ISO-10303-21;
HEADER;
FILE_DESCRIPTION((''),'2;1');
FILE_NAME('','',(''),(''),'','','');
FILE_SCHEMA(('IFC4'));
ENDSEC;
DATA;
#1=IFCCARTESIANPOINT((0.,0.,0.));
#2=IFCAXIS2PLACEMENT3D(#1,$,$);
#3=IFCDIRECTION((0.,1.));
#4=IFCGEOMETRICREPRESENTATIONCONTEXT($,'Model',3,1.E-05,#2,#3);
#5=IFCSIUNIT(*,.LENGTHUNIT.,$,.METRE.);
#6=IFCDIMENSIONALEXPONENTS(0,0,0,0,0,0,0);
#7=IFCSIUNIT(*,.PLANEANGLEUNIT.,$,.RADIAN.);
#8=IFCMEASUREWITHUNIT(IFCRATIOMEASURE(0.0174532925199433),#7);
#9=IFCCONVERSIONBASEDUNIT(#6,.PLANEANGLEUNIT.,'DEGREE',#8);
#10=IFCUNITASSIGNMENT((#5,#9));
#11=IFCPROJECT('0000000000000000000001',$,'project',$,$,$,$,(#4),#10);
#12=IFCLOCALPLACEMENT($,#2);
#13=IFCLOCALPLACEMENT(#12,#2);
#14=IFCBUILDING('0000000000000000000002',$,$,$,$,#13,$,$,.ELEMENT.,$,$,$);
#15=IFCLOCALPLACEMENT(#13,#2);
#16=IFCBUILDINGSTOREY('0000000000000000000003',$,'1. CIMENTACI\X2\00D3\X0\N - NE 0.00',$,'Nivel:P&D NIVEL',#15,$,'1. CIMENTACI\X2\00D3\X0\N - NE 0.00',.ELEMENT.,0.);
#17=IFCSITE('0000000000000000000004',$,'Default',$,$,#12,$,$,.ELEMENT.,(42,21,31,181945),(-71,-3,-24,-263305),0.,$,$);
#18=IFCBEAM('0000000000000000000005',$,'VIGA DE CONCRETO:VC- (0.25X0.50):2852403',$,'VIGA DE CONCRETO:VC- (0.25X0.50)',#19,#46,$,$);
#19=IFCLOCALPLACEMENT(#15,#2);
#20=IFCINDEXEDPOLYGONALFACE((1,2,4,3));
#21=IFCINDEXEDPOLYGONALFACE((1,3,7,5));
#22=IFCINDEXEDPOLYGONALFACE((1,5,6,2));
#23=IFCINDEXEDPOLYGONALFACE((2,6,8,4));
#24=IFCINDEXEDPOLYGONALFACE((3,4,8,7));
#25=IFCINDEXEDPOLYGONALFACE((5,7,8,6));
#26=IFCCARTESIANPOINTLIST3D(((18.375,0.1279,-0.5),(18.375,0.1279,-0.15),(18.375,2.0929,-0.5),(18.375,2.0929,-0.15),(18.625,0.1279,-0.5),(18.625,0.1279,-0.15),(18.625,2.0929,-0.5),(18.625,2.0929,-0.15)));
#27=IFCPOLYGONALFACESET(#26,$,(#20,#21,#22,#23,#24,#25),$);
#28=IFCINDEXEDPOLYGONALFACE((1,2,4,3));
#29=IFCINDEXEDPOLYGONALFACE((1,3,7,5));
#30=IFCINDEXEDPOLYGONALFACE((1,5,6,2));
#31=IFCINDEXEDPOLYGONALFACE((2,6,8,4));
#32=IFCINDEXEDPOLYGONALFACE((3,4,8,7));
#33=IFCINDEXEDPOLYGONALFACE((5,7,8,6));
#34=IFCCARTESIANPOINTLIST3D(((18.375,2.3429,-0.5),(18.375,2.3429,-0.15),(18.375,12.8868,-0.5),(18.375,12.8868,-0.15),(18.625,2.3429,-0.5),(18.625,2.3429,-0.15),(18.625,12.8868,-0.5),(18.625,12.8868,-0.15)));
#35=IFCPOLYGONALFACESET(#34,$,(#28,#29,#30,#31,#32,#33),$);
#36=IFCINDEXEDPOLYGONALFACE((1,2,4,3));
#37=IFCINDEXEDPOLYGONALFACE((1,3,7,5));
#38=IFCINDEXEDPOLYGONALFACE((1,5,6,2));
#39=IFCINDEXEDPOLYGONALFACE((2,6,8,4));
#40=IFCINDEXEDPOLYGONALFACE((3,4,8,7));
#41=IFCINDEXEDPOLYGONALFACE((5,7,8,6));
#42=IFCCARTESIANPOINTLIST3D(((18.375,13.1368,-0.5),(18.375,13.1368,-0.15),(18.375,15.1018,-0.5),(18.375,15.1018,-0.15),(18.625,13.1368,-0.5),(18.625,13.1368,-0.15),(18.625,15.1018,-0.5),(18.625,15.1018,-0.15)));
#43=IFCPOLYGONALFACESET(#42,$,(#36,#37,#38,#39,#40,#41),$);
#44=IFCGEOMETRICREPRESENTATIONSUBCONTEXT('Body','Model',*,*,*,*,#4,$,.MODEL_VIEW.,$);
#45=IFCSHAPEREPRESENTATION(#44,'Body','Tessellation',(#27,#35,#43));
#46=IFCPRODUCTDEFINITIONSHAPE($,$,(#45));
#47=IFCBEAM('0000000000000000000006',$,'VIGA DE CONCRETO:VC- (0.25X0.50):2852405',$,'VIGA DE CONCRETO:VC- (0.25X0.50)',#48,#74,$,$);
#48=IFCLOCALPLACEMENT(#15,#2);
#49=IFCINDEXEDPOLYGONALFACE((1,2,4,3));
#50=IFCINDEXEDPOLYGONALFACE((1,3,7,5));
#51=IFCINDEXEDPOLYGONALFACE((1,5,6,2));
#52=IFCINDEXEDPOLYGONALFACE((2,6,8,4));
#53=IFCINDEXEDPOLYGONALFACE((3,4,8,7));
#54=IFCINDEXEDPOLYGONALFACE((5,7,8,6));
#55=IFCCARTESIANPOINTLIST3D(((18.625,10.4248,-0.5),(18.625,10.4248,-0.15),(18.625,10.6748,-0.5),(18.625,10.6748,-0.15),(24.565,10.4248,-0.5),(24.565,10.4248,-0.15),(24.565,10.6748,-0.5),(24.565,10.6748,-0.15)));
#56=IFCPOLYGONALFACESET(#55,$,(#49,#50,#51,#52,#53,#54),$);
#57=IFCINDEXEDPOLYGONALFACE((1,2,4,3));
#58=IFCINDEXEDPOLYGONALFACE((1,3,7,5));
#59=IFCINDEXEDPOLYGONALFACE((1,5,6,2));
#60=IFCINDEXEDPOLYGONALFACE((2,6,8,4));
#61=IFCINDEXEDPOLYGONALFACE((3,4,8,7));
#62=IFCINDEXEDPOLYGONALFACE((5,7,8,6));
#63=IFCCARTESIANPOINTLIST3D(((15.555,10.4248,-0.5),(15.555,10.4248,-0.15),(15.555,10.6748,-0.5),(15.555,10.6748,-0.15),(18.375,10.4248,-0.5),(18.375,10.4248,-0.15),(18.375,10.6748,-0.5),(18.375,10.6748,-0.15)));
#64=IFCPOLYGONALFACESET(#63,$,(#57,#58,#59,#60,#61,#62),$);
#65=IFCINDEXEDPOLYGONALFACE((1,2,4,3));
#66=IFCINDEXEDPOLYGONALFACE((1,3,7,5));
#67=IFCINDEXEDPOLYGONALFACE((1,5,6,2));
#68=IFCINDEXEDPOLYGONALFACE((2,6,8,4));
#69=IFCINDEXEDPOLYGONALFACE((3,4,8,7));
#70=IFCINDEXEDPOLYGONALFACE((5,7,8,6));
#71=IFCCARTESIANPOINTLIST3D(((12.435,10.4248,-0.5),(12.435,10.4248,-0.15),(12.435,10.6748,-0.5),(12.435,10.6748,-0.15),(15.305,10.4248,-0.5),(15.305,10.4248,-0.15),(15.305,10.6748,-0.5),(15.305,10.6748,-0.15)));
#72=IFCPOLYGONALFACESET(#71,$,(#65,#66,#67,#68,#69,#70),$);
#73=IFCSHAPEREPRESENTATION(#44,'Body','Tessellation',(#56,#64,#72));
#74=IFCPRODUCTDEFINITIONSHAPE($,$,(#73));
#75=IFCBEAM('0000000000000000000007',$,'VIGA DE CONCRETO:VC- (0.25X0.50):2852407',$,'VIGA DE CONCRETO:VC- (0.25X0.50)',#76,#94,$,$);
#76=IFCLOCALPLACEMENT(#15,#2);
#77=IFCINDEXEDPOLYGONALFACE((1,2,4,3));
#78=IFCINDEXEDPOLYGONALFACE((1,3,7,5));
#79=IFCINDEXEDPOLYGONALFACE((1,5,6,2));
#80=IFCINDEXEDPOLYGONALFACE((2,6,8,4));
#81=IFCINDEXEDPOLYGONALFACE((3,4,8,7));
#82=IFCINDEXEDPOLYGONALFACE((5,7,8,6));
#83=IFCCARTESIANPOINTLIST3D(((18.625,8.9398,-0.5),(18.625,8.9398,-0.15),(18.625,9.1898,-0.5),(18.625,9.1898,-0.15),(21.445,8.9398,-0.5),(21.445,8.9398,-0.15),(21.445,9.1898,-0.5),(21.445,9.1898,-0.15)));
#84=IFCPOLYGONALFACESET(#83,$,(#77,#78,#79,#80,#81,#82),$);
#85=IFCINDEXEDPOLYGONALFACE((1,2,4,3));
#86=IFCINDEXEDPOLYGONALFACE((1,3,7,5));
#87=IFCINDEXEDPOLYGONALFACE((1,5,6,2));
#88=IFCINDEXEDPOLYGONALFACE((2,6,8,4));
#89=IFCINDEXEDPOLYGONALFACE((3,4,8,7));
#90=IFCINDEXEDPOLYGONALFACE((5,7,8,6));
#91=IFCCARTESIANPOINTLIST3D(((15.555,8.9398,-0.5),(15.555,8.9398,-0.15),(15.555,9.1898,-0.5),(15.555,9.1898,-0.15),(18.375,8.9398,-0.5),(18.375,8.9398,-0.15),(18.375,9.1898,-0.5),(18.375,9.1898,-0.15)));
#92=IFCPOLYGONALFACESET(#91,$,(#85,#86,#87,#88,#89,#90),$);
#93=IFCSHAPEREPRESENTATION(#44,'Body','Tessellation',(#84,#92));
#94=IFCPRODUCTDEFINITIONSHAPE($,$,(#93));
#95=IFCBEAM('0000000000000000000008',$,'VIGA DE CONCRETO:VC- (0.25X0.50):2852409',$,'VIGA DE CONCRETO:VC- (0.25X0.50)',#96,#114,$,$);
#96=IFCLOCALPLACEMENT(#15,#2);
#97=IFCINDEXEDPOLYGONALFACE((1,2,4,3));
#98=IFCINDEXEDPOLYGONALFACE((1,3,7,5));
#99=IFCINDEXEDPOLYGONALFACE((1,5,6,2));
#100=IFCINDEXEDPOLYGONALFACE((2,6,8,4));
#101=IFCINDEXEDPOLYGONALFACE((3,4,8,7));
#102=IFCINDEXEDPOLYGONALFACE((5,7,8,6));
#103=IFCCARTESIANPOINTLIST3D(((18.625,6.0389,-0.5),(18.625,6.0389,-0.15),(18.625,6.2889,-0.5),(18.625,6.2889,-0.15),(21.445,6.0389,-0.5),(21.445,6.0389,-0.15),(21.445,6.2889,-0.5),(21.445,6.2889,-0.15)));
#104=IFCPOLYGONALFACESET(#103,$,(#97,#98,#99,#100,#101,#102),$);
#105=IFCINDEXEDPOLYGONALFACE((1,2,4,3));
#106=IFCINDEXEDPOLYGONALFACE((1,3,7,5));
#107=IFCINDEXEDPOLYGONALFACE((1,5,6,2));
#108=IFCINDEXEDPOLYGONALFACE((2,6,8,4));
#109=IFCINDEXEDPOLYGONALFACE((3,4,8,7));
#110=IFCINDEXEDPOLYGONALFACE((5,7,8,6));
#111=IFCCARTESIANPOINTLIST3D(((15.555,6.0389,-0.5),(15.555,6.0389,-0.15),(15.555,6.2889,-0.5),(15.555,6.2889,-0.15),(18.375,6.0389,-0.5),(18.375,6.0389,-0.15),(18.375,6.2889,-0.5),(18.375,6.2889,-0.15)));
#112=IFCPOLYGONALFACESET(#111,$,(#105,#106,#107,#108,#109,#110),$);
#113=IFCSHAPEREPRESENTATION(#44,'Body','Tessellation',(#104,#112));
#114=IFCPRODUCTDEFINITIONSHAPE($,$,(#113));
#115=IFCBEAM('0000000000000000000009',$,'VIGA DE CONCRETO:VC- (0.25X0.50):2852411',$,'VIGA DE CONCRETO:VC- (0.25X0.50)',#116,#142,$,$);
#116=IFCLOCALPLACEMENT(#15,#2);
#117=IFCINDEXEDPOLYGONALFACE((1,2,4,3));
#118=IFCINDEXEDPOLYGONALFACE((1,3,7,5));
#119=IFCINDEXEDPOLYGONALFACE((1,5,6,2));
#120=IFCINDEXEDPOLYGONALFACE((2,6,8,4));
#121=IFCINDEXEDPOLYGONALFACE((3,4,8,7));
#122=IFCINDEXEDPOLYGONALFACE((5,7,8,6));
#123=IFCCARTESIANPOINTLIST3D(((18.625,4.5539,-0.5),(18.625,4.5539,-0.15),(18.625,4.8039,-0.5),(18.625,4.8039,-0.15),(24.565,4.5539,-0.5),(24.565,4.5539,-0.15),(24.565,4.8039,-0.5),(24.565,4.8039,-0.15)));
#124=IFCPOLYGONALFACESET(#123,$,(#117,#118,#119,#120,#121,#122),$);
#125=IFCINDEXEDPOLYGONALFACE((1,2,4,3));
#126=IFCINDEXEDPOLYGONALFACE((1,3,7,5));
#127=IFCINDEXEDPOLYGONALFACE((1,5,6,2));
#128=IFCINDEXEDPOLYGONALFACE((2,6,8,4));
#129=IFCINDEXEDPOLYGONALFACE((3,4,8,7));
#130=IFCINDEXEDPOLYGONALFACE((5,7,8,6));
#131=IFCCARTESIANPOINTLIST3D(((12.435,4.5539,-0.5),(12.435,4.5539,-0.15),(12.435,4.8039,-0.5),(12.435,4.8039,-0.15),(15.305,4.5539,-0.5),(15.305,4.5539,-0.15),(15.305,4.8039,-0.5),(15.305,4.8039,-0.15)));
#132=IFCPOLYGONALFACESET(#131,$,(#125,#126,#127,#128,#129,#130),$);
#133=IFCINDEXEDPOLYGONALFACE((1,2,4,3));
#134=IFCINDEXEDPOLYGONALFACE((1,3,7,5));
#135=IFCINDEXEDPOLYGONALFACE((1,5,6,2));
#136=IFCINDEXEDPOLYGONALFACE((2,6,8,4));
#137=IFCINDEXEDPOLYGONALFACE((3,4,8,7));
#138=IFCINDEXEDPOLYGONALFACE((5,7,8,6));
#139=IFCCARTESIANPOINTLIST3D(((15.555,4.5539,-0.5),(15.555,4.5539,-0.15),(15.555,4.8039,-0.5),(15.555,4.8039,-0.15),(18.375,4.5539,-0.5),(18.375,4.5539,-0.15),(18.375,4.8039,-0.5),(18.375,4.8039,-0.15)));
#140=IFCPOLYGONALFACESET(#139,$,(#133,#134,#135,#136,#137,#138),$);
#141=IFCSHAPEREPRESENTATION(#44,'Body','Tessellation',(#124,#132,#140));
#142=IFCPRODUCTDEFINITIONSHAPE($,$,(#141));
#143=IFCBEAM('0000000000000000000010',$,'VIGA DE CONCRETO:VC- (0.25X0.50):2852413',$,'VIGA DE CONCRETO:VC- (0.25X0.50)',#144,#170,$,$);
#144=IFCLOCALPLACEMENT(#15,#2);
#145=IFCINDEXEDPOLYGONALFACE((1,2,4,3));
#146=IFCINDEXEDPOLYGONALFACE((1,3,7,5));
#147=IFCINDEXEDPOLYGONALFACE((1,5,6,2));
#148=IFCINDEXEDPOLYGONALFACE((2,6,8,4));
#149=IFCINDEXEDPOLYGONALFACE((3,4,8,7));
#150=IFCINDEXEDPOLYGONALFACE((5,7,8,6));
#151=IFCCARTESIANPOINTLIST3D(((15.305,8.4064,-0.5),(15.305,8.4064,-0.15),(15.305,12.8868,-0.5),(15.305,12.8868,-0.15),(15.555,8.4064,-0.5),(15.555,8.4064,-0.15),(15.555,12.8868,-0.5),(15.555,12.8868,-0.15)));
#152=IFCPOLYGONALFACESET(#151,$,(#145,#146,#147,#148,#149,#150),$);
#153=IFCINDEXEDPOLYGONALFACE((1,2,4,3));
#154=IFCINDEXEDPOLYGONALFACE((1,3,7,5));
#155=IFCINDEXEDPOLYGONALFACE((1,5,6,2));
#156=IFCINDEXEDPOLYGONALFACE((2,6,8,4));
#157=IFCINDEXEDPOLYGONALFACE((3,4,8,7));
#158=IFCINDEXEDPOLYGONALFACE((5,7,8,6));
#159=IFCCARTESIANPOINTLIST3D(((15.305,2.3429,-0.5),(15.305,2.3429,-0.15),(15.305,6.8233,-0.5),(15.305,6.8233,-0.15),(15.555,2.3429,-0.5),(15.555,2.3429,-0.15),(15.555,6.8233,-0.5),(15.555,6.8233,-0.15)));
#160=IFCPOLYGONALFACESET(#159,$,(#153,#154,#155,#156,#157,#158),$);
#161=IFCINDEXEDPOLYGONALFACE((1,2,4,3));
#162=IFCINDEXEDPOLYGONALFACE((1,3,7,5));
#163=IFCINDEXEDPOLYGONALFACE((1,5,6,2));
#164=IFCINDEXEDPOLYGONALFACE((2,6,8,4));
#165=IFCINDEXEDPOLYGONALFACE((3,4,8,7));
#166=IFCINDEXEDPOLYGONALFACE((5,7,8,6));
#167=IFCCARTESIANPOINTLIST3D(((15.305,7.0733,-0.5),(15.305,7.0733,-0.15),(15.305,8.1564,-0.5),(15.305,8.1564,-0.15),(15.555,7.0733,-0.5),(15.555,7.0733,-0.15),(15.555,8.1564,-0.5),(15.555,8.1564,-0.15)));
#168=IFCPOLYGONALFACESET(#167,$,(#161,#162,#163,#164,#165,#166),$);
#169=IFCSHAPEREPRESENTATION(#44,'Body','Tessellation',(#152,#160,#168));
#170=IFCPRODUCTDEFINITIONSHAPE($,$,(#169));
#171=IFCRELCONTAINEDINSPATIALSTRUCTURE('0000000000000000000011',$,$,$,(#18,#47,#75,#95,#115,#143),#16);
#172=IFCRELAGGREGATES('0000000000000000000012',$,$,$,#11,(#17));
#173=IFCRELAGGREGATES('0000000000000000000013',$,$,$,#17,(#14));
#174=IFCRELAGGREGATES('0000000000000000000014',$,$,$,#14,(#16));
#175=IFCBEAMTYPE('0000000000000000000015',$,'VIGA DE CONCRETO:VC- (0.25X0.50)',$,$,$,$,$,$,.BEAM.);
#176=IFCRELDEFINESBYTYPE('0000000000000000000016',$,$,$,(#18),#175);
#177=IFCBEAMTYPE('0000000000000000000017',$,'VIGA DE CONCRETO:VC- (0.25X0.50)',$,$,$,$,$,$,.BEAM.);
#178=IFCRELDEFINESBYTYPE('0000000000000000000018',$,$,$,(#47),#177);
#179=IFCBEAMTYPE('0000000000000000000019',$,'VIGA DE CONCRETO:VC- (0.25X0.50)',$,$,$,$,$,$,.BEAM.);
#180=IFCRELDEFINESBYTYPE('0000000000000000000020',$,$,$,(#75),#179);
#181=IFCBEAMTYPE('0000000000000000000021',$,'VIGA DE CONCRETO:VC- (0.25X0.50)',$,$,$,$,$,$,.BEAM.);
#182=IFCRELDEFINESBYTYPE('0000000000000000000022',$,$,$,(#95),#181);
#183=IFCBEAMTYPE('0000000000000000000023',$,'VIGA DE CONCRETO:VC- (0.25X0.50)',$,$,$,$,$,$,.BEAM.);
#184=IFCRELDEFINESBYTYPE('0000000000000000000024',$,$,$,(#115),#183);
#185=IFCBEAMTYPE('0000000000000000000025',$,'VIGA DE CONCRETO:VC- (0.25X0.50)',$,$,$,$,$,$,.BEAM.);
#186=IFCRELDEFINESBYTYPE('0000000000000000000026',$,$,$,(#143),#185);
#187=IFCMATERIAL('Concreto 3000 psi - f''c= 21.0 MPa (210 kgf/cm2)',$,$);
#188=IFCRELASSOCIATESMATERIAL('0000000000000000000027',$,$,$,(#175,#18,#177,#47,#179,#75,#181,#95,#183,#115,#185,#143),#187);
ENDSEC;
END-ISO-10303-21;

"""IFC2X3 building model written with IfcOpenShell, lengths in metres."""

from ifc_helpers import new_model, entity, si_unit, converted_unit, direction, frame, frame_2d, origin, place, context, subcontext, project, spatial, rectangle, extrude, source, transform, mapped, material, type_object, type_shapes, element, save


model = new_model("IFC2X3")

# Units and contexts
model_context = context("Model", 3, precision=1e-05, world=origin(), true_north=direction((0.0, 1.0)))
body_context = subcontext(model_context, "Body", "Model", "MODEL_VIEW")
ifc_project = project(units=[si_unit("LENGTHUNIT", "METRE"), converted_unit("PLANEANGLEUNIT", "DEGREE", entity("IfcRatioMeasure", 0.0174532925199433), si_unit("PLANEANGLEUNIT", "RADIAN"), dimensions=[0, 0, 0, 0, 0, 0, 0])], contexts=[model_context])

# Site, building, storey
site_placement = place(None, origin())
site = spatial("IfcSite", under=ifc_project, at=site_placement, Name="Default", CompositionType="ELEMENT", RefLatitude=(42, 21, 31, 181945), RefLongitude=(-71, -3, -24, -263305), RefElevation=0.0)
building_placement = place(site_placement, origin())
building = spatial("IfcBuilding", under=site, at=building_placement, CompositionType="ELEMENT")
storey_placement = place(building_placement, origin())
storey = spatial("IfcBuildingStorey", under=building, at=storey_placement, Name="1. CIMENTACIÓN - NE 0.00", ObjectType="Nivel:P&D NIVEL", LongName="1. CIMENTACIÓN - NE 0.00", CompositionType="ELEMENT", Elevation=0.0)

# Beams
ifc_material = material(Name="Concreto 3000 psi - f'c= 21.0 MPa (210 kgf/cm2)")
beam_type_1 = type_object("IfcBeamType", Name="VIGA DE CONCRETO:VC- (0.25X0.50)", PredefinedType="BEAM", material=ifc_material)
shared_shape_1 = source(origin(), body_context, "Body", "SweptSolid", [
    extrude(rectangle(XDim=0.35, YDim=0.25, at=frame_2d((0.0, 0.0), x_axis=(0.0, 1.0))), frame((18.5, 0.1279, -0.325), z_axis=(0.0, 1.0, 0.0), x_axis=(-1.0, 0.0, 0.0)), (0.0, 0.0, 1.0), 1.965),
    extrude(rectangle(XDim=0.35, YDim=0.25, at=frame_2d((0.0, 0.0), x_axis=(0.0, 1.0))), frame((18.5, 2.3429, -0.325), z_axis=(0.0, 1.0, 0.0), x_axis=(-1.0, 0.0, 0.0)), (0.0, 0.0, 1.0), 10.5439),
    extrude(rectangle(XDim=0.35, YDim=0.25, at=frame_2d((0.0, 0.0), x_axis=(0.0, 1.0))), frame((18.5, 13.1368, -0.325), z_axis=(0.0, 1.0, 0.0), x_axis=(-1.0, 0.0, 0.0)), (0.0, 0.0, 1.0), 1.965),
])
type_shapes(beam_type_1, [shared_shape_1])
beam_1_placement = place(storey_placement, origin())
element("IfcBeam", 1, at=beam_1_placement, inside=storey, type_object=beam_type_1, material=ifc_material, Name="VIGA DE CONCRETO:VC- (0.25X0.50):2852403", ObjectType="VIGA DE CONCRETO:VC- (0.25X0.50)", context=body_context, shape_type="MappedRepresentation", body=[
    mapped(shared_shape_1, transform((0.0, 0.0, 0.0), scale=1.0)),
])
beam_type_2 = type_object("IfcBeamType", Name="VIGA DE CONCRETO:VC- (0.25X0.50)", PredefinedType="BEAM", material=ifc_material)
shared_shape_2 = source(origin(), body_context, "Body", "SweptSolid", [
    extrude(rectangle(XDim=0.35, YDim=0.25, at=frame_2d((0.0, 0.0), x_axis=(1.0, 0.0))), frame((24.565, 10.5498, -0.325), z_axis=(-1.0, 0.0, 0.0), x_axis=(0.0, 0.0, -1.0)), (0.0, 0.0, 1.0), 5.94),
    extrude(rectangle(XDim=0.35, YDim=0.25, at=frame_2d((0.0, 0.0), x_axis=(1.0, 0.0))), frame((18.375, 10.5498, -0.325), z_axis=(-1.0, 0.0, 0.0), x_axis=(0.0, 0.0, -1.0)), (0.0, 0.0, 1.0), 2.82),
    extrude(rectangle(XDim=0.35, YDim=0.25, at=frame_2d((0.0, 0.0), x_axis=(1.0, 0.0))), frame((15.305, 10.5498, -0.325), z_axis=(-1.0, 0.0, 0.0), x_axis=(0.0, 0.0, -1.0)), (0.0, 0.0, 1.0), 2.87),
])
type_shapes(beam_type_2, [shared_shape_2])
beam_2_placement = place(storey_placement, origin())
element("IfcBeam", 2, at=beam_2_placement, inside=storey, type_object=beam_type_2, material=ifc_material, Name="VIGA DE CONCRETO:VC- (0.25X0.50):2852405", ObjectType="VIGA DE CONCRETO:VC- (0.25X0.50)", context=body_context, shape_type="MappedRepresentation", body=[
    mapped(shared_shape_2, transform((0.0, 0.0, 0.0), scale=1.0)),
])
beam_type_3 = type_object("IfcBeamType", Name="VIGA DE CONCRETO:VC- (0.25X0.50)", PredefinedType="BEAM", material=ifc_material)
shared_shape_3 = source(origin(), body_context, "Body", "SweptSolid", [
    extrude(rectangle(XDim=0.35, YDim=0.25, at=frame_2d((0.0, 0.0), x_axis=(1.0, 0.0))), frame((21.445, 9.0648, -0.325), z_axis=(-1.0, 0.0, 0.0), x_axis=(0.0, 0.0, -1.0)), (0.0, 0.0, 1.0), 2.82),
    extrude(rectangle(XDim=0.35, YDim=0.25, at=frame_2d((0.0, 0.0), x_axis=(1.0, 0.0))), frame((18.375, 9.0648, -0.325), z_axis=(-1.0, 0.0, 0.0), x_axis=(0.0, 0.0, -1.0)), (0.0, 0.0, 1.0), 2.82),
])
type_shapes(beam_type_3, [shared_shape_3])
beam_3_placement = place(storey_placement, origin())
element("IfcBeam", 3, at=beam_3_placement, inside=storey, type_object=beam_type_3, material=ifc_material, Name="VIGA DE CONCRETO:VC- (0.25X0.50):2852407", ObjectType="VIGA DE CONCRETO:VC- (0.25X0.50)", context=body_context, shape_type="MappedRepresentation", body=[
    mapped(shared_shape_3, transform((0.0, 0.0, 0.0), scale=1.0)),
])
beam_type_4 = type_object("IfcBeamType", Name="VIGA DE CONCRETO:VC- (0.25X0.50)", PredefinedType="BEAM", material=ifc_material)
shared_shape_4 = source(origin(), body_context, "Body", "SweptSolid", [
    extrude(rectangle(XDim=0.35, YDim=0.25, at=frame_2d((0.0, 0.0), x_axis=(1.0, 0.0))), frame((21.445, 6.1639, -0.325), z_axis=(-1.0, 0.0, 0.0), x_axis=(0.0, 0.0, -1.0)), (0.0, 0.0, 1.0), 2.82),
    extrude(rectangle(XDim=0.35, YDim=0.25, at=frame_2d((0.0, 0.0), x_axis=(1.0, 0.0))), frame((18.375, 6.1639, -0.325), z_axis=(-1.0, 0.0, 0.0), x_axis=(0.0, 0.0, -1.0)), (0.0, 0.0, 1.0), 2.82),
])
type_shapes(beam_type_4, [shared_shape_4])
beam_4_placement = place(storey_placement, origin())
element("IfcBeam", 4, at=beam_4_placement, inside=storey, type_object=beam_type_4, material=ifc_material, Name="VIGA DE CONCRETO:VC- (0.25X0.50):2852409", ObjectType="VIGA DE CONCRETO:VC- (0.25X0.50)", context=body_context, shape_type="MappedRepresentation", body=[
    mapped(shared_shape_4, transform((0.0, 0.0, 0.0), scale=1.0)),
])
beam_type_5 = type_object("IfcBeamType", Name="VIGA DE CONCRETO:VC- (0.25X0.50)", PredefinedType="BEAM", material=ifc_material)
shared_shape_5 = source(origin(), body_context, "Body", "SweptSolid", [
    extrude(rectangle(XDim=0.35, YDim=0.25, at=frame_2d((0.0, 0.0), x_axis=(1.0, 0.0))), frame((24.565, 4.6789, -0.325), z_axis=(-1.0, 0.0, 0.0), x_axis=(0.0, 0.0, -1.0)), (0.0, 0.0, 1.0), 5.94),
    extrude(rectangle(XDim=0.35, YDim=0.25, at=frame_2d((0.0, 0.0), x_axis=(1.0, 0.0))), frame((15.305, 4.6789, -0.325), z_axis=(-1.0, 0.0, 0.0), x_axis=(0.0, 0.0, -1.0)), (0.0, 0.0, 1.0), 2.87),
    extrude(rectangle(XDim=0.35, YDim=0.25, at=frame_2d((0.0, 0.0), x_axis=(1.0, 0.0))), frame((18.375, 4.6789, -0.325), z_axis=(-1.0, 0.0, 0.0), x_axis=(0.0, 0.0, -1.0)), (0.0, 0.0, 1.0), 2.82),
])
type_shapes(beam_type_5, [shared_shape_5])
beam_5_placement = place(storey_placement, origin())
element("IfcBeam", 5, at=beam_5_placement, inside=storey, type_object=beam_type_5, material=ifc_material, Name="VIGA DE CONCRETO:VC- (0.25X0.50):2852411", ObjectType="VIGA DE CONCRETO:VC- (0.25X0.50)", context=body_context, shape_type="MappedRepresentation", body=[
    mapped(shared_shape_5, transform((0.0, 0.0, 0.0), scale=1.0)),
])
beam_type_6 = type_object("IfcBeamType", Name="VIGA DE CONCRETO:VC- (0.25X0.50)", PredefinedType="BEAM", material=ifc_material)
shared_shape_6 = source(origin(), body_context, "Body", "SweptSolid", [
    extrude(rectangle(XDim=0.35, YDim=0.25, at=frame_2d((0.0, 0.0), x_axis=(0.0, 1.0))), frame((15.43, 12.8868, -0.325), z_axis=(0.0, -1.0, 0.0), x_axis=(-1.0, 0.0, 0.0)), (0.0, 0.0, 1.0), 4.4804),
    extrude(rectangle(XDim=0.35, YDim=0.25, at=frame_2d((0.0, 0.0), x_axis=(0.0, 1.0))), frame((15.43, 6.8233, -0.325), z_axis=(0.0, -1.0, 0.0), x_axis=(-1.0, 0.0, 0.0)), (0.0, 0.0, 1.0), 4.4804),
    extrude(rectangle(XDim=0.35, YDim=0.25, at=frame_2d((0.0, 0.0), x_axis=(0.0, 1.0))), frame((15.43, 8.1564, -0.325), z_axis=(0.0, -1.0, 0.0), x_axis=(-1.0, 0.0, 0.0)), (0.0, 0.0, 1.0), 1.0831),
])
type_shapes(beam_type_6, [shared_shape_6])
beam_6_placement = place(storey_placement, origin())
element("IfcBeam", 6, at=beam_6_placement, inside=storey, type_object=beam_type_6, material=ifc_material, Name="VIGA DE CONCRETO:VC- (0.25X0.50):2852413", ObjectType="VIGA DE CONCRETO:VC- (0.25X0.50)", context=body_context, shape_type="MappedRepresentation", body=[
    mapped(shared_shape_6, transform((0.0, 0.0, 0.0), scale=1.0)),
])

save(model, "model.ifc")
